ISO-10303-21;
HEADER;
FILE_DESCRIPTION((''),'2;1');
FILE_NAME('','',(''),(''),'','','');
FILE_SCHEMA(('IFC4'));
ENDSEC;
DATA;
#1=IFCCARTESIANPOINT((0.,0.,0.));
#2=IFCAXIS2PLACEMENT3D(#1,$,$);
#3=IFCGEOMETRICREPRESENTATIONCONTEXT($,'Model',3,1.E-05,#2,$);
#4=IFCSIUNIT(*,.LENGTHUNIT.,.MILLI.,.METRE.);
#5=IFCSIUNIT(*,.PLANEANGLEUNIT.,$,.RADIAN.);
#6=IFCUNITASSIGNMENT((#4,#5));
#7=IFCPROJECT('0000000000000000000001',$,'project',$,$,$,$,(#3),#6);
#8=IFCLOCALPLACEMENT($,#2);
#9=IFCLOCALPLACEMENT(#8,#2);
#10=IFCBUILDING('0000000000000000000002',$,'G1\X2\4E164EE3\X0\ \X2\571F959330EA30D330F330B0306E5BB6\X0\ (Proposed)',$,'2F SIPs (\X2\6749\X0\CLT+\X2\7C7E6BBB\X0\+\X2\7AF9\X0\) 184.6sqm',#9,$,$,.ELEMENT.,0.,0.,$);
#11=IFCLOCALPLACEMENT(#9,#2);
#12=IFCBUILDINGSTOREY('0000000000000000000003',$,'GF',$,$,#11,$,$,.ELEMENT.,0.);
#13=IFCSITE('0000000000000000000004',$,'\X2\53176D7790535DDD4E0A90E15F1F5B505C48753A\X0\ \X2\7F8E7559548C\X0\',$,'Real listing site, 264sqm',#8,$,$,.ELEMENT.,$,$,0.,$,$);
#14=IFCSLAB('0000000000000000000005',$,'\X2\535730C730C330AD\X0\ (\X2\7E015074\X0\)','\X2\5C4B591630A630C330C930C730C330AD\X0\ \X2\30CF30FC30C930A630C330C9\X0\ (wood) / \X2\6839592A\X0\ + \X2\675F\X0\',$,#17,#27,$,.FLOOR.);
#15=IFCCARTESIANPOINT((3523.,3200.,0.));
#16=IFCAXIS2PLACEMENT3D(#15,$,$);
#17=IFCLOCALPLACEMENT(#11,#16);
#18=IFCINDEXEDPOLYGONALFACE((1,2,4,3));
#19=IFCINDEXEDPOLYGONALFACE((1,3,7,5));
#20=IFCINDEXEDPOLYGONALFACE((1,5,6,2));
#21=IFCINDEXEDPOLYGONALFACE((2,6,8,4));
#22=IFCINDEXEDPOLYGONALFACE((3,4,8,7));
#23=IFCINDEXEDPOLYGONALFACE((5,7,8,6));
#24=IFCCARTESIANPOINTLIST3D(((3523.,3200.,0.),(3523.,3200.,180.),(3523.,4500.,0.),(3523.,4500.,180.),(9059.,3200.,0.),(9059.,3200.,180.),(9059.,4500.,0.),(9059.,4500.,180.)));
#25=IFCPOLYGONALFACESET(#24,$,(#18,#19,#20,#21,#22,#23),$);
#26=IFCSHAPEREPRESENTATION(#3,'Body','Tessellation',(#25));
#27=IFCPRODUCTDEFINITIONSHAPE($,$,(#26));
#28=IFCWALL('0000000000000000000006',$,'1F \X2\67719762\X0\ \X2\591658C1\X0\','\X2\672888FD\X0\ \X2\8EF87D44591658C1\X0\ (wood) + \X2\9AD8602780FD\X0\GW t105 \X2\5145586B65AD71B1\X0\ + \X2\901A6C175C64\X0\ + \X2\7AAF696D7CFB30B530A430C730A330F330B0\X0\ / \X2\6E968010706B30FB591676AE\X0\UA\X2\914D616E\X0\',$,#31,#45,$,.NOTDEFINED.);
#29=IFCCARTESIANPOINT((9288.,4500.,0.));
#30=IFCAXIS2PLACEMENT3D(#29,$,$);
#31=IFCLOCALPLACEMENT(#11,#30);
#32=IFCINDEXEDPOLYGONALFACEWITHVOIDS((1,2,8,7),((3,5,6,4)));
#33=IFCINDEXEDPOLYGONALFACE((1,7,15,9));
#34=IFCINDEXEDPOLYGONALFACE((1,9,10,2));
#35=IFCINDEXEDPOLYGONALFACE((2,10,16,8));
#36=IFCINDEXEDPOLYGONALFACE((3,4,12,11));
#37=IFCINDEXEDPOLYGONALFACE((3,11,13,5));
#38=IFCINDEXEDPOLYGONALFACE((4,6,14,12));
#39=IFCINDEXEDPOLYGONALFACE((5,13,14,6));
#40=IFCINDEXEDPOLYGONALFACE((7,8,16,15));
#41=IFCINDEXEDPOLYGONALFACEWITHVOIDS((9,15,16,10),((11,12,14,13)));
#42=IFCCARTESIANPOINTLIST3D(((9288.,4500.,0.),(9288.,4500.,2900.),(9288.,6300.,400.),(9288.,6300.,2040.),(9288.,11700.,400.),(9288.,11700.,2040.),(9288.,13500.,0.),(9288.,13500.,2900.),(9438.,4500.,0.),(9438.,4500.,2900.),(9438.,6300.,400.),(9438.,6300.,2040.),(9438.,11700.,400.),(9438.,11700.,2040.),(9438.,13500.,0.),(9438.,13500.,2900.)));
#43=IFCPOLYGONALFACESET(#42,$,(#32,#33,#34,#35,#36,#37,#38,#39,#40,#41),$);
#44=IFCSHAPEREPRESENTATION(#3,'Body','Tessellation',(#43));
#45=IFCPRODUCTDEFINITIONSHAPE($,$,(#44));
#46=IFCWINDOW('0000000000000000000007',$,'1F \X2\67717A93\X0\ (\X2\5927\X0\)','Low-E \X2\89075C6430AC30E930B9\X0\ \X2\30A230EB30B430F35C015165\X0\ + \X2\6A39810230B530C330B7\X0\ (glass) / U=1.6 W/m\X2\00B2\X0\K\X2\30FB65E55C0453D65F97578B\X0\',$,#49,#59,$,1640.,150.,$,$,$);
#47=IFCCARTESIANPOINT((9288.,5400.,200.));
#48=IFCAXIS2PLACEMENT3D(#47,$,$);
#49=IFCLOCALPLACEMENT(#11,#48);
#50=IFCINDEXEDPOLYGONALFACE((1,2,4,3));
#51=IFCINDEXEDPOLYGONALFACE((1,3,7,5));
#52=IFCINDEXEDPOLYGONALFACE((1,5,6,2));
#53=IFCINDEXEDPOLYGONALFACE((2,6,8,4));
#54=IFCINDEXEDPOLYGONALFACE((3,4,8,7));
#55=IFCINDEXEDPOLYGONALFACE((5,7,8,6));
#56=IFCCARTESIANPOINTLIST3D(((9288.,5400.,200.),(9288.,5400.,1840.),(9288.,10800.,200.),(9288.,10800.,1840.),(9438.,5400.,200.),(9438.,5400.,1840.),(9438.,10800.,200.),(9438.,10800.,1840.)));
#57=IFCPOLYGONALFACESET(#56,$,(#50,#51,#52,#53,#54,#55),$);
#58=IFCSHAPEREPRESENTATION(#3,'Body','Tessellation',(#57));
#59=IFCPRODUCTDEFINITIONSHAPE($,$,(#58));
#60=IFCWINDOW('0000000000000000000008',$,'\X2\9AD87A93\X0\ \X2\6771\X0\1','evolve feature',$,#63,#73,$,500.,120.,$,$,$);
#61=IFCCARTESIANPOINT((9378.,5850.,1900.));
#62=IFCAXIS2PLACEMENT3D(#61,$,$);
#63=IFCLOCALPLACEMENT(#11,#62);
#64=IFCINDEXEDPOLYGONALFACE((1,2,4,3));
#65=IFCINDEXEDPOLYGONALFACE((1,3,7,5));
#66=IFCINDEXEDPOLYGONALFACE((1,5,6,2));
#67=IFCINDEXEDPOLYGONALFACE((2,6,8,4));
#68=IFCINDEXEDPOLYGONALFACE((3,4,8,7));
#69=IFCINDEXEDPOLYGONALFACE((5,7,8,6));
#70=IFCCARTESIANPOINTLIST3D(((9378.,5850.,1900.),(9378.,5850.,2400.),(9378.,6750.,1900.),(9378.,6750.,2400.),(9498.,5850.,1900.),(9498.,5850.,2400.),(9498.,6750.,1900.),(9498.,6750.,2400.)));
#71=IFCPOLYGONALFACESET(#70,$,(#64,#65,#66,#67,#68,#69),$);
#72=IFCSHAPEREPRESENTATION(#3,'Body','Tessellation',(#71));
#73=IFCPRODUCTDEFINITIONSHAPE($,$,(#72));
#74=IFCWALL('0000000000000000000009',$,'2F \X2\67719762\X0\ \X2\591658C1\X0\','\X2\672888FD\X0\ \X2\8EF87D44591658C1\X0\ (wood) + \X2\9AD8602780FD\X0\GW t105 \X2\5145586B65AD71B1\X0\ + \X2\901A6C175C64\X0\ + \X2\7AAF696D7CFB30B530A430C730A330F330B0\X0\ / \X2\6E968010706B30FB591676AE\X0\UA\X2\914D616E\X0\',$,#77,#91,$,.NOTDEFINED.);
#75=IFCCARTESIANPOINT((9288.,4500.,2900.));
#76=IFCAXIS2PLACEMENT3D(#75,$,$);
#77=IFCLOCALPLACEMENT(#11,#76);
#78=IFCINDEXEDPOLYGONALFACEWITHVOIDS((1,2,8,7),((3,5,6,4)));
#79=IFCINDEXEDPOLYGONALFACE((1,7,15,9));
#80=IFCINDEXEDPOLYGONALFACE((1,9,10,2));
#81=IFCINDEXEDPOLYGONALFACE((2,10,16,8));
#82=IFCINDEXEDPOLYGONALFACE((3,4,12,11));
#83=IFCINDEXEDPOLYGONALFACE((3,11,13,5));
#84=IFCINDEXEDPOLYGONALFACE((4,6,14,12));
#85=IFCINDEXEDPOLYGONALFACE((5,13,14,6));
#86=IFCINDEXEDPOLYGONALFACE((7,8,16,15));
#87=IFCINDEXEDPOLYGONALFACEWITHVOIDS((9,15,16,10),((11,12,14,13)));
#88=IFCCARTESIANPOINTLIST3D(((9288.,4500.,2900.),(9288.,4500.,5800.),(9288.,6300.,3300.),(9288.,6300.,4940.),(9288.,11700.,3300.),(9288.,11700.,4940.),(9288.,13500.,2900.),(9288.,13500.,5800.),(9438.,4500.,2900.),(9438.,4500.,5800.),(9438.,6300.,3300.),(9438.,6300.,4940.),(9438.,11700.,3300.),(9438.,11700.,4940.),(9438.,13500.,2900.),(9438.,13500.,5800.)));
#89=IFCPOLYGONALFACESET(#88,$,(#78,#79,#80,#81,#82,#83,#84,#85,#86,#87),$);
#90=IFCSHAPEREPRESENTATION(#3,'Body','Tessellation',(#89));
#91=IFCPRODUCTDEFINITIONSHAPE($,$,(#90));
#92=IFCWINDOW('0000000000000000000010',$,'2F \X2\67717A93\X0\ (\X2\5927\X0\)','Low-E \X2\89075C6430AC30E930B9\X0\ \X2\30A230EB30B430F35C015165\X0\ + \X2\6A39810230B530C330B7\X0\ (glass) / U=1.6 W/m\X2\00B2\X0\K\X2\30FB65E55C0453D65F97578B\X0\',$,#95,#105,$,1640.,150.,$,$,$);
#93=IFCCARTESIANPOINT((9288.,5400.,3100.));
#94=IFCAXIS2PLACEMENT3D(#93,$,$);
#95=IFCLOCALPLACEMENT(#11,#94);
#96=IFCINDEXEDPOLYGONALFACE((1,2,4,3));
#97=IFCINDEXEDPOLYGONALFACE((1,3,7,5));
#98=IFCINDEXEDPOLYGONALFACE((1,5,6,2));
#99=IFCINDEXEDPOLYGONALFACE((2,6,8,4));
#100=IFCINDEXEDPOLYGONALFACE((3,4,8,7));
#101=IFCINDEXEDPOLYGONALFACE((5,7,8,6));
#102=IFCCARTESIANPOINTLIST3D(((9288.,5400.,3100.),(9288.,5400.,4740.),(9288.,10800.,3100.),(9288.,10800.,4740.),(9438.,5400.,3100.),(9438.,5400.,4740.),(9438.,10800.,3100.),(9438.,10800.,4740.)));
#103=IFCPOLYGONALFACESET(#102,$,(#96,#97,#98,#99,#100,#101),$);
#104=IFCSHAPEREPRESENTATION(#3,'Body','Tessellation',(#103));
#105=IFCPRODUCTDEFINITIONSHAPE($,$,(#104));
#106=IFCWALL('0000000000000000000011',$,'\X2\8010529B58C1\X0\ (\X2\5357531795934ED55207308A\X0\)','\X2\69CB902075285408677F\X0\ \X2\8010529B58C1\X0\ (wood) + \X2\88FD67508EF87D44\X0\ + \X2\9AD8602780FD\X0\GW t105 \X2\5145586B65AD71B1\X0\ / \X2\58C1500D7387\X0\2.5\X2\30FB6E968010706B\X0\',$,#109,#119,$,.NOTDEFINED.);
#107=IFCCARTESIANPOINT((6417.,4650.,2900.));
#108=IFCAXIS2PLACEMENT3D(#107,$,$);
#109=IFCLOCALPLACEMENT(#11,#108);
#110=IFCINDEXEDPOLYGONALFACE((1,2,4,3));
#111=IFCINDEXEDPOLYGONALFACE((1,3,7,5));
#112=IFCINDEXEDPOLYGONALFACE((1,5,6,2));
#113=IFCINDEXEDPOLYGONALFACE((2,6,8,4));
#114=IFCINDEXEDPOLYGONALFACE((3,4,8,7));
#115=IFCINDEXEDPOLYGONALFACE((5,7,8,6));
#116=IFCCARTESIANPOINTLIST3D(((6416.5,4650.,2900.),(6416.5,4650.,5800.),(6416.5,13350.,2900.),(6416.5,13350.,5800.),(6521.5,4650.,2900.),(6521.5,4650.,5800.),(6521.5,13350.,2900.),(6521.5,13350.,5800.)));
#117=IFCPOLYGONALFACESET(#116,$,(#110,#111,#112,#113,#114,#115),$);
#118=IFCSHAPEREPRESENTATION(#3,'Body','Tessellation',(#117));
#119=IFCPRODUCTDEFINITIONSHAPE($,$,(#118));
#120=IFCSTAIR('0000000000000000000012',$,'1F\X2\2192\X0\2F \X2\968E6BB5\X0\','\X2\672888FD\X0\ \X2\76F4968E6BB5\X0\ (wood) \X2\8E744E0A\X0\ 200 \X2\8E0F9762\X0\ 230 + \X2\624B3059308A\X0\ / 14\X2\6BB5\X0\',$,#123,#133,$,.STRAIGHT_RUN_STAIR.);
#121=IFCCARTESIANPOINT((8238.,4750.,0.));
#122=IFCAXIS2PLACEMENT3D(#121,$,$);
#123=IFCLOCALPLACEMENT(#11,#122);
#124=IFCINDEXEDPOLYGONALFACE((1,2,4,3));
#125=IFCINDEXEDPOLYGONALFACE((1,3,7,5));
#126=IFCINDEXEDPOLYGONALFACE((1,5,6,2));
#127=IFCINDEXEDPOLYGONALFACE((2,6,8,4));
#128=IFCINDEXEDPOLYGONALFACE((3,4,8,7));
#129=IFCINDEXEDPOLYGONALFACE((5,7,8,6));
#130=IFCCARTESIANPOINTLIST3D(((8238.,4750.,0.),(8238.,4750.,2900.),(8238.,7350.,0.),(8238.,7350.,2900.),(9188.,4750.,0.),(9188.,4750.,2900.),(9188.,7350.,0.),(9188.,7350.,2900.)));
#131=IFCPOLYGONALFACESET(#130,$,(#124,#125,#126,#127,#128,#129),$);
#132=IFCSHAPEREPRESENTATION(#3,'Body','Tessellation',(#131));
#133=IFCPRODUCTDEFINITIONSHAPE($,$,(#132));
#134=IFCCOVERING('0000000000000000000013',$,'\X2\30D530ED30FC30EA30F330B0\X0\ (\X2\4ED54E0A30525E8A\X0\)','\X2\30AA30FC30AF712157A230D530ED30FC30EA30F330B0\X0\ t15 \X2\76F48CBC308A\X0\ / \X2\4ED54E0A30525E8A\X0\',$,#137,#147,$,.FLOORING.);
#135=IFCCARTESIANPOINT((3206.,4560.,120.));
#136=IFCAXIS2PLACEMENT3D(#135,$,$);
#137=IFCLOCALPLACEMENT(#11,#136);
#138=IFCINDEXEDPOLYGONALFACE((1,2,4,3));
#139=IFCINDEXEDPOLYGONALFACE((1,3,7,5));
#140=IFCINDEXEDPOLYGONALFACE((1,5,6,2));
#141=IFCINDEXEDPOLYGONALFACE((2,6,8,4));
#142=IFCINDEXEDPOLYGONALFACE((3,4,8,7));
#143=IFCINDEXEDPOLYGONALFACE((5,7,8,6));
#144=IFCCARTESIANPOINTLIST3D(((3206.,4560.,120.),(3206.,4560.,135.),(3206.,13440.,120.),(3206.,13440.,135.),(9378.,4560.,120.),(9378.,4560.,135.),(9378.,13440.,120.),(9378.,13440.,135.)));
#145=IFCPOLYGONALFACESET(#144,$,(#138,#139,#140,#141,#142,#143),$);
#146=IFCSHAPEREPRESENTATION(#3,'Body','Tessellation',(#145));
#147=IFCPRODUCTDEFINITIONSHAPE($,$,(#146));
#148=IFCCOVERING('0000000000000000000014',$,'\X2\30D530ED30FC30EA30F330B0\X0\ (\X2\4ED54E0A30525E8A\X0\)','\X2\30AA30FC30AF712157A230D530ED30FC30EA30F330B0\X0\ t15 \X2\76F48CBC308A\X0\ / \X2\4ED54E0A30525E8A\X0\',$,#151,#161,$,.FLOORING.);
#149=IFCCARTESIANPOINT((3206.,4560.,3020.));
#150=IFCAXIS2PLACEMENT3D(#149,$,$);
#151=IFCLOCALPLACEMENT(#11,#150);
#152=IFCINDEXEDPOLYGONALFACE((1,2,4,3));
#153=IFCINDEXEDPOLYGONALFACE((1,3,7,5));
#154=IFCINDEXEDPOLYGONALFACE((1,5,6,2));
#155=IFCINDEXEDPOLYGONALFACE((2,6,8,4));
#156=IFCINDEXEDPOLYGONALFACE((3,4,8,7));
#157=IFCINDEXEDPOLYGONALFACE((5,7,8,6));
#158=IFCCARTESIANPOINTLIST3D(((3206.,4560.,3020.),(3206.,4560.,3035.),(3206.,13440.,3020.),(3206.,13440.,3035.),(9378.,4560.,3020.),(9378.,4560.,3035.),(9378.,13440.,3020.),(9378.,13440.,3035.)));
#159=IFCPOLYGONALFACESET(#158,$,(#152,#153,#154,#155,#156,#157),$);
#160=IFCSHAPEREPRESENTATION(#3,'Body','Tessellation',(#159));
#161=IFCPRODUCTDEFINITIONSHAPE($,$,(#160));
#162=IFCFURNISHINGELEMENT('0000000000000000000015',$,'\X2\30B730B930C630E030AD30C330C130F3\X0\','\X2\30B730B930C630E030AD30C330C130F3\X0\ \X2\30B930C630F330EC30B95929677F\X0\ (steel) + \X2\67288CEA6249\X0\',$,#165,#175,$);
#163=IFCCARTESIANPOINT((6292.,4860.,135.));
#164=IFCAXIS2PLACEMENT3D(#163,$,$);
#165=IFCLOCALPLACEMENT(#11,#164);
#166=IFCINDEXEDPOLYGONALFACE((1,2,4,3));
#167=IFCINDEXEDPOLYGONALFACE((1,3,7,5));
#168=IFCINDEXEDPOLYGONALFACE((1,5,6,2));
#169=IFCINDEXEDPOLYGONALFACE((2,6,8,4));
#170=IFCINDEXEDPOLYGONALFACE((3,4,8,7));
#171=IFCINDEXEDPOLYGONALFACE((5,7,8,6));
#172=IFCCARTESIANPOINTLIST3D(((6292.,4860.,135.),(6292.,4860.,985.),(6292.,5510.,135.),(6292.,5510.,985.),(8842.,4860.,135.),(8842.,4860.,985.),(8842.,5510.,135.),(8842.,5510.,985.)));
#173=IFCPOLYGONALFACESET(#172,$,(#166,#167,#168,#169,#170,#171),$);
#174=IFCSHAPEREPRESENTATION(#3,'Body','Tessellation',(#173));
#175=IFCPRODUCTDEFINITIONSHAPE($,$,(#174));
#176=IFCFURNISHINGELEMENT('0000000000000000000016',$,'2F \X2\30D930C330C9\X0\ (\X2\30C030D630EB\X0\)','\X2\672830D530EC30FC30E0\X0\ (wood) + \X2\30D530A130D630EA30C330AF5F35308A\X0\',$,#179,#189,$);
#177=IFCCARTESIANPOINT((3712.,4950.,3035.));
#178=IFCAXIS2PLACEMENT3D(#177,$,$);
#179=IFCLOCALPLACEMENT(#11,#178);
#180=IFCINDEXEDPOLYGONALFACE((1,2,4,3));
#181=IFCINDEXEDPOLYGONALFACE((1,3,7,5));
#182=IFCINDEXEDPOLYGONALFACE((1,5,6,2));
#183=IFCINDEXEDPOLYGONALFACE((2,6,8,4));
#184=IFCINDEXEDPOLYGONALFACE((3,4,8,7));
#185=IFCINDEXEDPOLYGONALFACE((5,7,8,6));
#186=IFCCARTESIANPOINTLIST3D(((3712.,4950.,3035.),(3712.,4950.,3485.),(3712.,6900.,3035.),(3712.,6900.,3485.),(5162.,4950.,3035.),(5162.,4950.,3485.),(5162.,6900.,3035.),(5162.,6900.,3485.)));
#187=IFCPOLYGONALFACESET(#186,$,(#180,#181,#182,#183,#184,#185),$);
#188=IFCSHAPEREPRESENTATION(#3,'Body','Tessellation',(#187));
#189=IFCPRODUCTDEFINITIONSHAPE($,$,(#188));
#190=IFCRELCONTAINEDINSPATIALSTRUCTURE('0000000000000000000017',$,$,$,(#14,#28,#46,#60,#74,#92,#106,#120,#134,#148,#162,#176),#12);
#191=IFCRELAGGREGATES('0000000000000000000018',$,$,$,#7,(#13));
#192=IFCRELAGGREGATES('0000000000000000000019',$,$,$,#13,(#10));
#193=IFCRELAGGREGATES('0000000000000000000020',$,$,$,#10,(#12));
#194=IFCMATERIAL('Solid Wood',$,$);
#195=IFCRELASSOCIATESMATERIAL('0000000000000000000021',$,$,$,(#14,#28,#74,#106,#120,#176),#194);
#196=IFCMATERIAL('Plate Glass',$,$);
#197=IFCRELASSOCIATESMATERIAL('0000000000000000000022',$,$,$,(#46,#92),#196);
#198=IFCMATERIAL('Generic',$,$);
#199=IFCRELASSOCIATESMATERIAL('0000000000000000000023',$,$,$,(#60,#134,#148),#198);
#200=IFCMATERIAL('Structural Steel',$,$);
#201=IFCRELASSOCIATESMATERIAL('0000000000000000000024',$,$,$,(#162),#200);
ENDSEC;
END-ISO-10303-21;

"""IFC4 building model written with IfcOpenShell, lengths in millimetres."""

from ifc_helpers import new_model, si_unit, frame, frame_2d, origin, place, context, project, spatial, rectangle, extrude, material, element, fill, save


model = new_model("IFC4")

# Units and contexts
model_context = context("Model", 3, precision=1e-05, world=origin())
ifc_project = project(units=[si_unit("LENGTHUNIT", "METRE", prefix="MILLI"), si_unit("PLANEANGLEUNIT", "RADIAN")], contexts=[model_context])

# Site, building, storey
site_placement = place(None, origin())
site = spatial("IfcSite", under=ifc_project, at=site_placement, Name="北海道川上郡弟子屈町 美留和", ObjectType="Real listing site, 264sqm", CompositionType="ELEMENT", RefElevation=0.0)
building_placement = place(site_placement, origin())
building = spatial("IfcBuilding", under=site, at=building_placement, Name="G1世代 土間リビングの家 (Proposed)", ObjectType="2F SIPs (杉CLT+籾殻+竹) 184.6sqm", CompositionType="ELEMENT", ElevationOfRefHeight=0.0, ElevationOfTerrain=0.0)
storey_placement = place(building_placement, origin())
storey = spatial("IfcBuildingStorey", under=building, at=storey_placement, Name="GF", CompositionType="ELEMENT", Elevation=0.0)

# Slab
ifc_material_1 = material(Name="Solid Wood")
slab_placement = place(storey_placement, frame((3523.0, 3200.0, 0.0)))
element("IfcSlab", 1, at=slab_placement, inside=storey, material=ifc_material_1, Name="南デッキ (縁側)", Description="屋外ウッドデッキ ハードウッド (wood) / 根太 + 束", PredefinedType="FLOOR", context=model_context, shape_type="SweptSolid", body=[
    extrude(rectangle(XDim=5536.0, YDim=1300.0, at=frame_2d((2768.0, 650.0))), frame((3523.0, 3200.0, 0.0)), (0.0, 0.0, 1.0), 180.0),
])

# Wall, openings, windows
wall_1_placement = place(storey_placement, frame((9288.0, 4500.0, 0.0)))
wall_1 = element("IfcWall", 2, at=wall_1_placement, inside=storey, material=ifc_material_1, Name="1F 東面 外壁", Description="木製 軸組外壁 (wood) + 高性能GW t105 充填断熱 + 通気層 + 窯業系サイディング / 準耐火・外皮UA配慮", PredefinedType="NOTDEFINED", context=model_context, shape_type="SweptSolid", body=[
    extrude(rectangle(XDim=150.0, YDim=9000.0, at=frame_2d((75.0, 4500.0))), frame((9288.0, 4500.0, 0.0)), (0.0, 0.0, 1.0), 2900.0),
])
opening_1_placement = place(storey_placement, frame((9288.0, 5400.0, 200.0)))
opening_1 = element("IfcOpeningElement", 3, at=opening_1_placement, cuts=wall_1, PredefinedType="NOTDEFINED", context=model_context, shape_type="SweptSolid", body=[
    extrude(rectangle(XDim=150.0, YDim=5400.0, at=frame_2d((75.0, 2700.0))), frame((9288.0, 5400.0, 200.0)), (0.0, 0.0, 1.0), 1640.0),
])
opening_2_placement = place(storey_placement, frame((9378.0, 5850.0, 1900.0)))
opening_2 = element("IfcOpeningElement", 4, at=opening_2_placement, cuts=wall_1, PredefinedType="NOTDEFINED", context=model_context, shape_type="SweptSolid", body=[
    extrude(rectangle(XDim=120.0, YDim=900.0, at=frame_2d((60.0, 450.0))), frame((9378.0, 5850.0, 1900.0)), (0.0, 0.0, 1.0), 500.0),
])
ifc_material_2 = material(Name="Plate Glass")
window_1_placement = place(storey_placement, frame((9288.0, 5400.0, 200.0)))
window_1 = element("IfcWindow", 5, at=window_1_placement, inside=storey, material=ifc_material_2, Name="1F 東窓 (大)", Description="Low-E 複層ガラス アルゴン封入 + 樹脂サッシ (glass) / U=1.6 W/m²K・日射取得型", OverallHeight=1640.0, OverallWidth=150.0, context=model_context, shape_type="SweptSolid", body=[
    extrude(rectangle(XDim=150.0, YDim=5400.0, at=frame_2d((75.0, 2700.0))), frame((9288.0, 5400.0, 200.0)), (0.0, 0.0, 1.0), 1640.0),
])
fill(opening_1, window_1)
ifc_material_3 = material(Name="Generic")
window_2_placement = place(storey_placement, frame((9378.0, 5850.0, 1900.0)))
window_2 = element("IfcWindow", 6, at=window_2_placement, inside=storey, material=ifc_material_3, Name="高窓 東1", Description="evolve feature", OverallHeight=500.0, OverallWidth=120.0, context=model_context, shape_type="SweptSolid", body=[
    extrude(rectangle(XDim=120.0, YDim=900.0, at=frame_2d((60.0, 450.0))), frame((9378.0, 5850.0, 1900.0)), (0.0, 0.0, 1.0), 500.0),
])
fill(opening_2, window_2)

# Wall, opening, window
wall_2_placement = place(storey_placement, frame((9288.0, 4500.0, 2900.0)))
wall_2 = element("IfcWall", 7, at=wall_2_placement, inside=storey, material=ifc_material_1, Name="2F 東面 外壁", Description="木製 軸組外壁 (wood) + 高性能GW t105 充填断熱 + 通気層 + 窯業系サイディング / 準耐火・外皮UA配慮", PredefinedType="NOTDEFINED", context=model_context, shape_type="SweptSolid", body=[
    extrude(rectangle(XDim=150.0, YDim=9000.0, at=frame_2d((75.0, 4500.0))), frame((9288.0, 4500.0, 2900.0)), (0.0, 0.0, 1.0), 2900.0),
])
opening_3_placement = place(storey_placement, frame((9288.0, 5400.0, 3100.0)))
opening_3 = element("IfcOpeningElement", 8, at=opening_3_placement, cuts=wall_2, PredefinedType="NOTDEFINED", context=model_context, shape_type="SweptSolid", body=[
    extrude(rectangle(XDim=150.0, YDim=5400.0, at=frame_2d((75.0, 2700.0))), frame((9288.0, 5400.0, 3100.0)), (0.0, 0.0, 1.0), 1640.0),
])
window_3_placement = place(storey_placement, frame((9288.0, 5400.0, 3100.0)))
window_3 = element("IfcWindow", 9, at=window_3_placement, inside=storey, material=ifc_material_2, Name="2F 東窓 (大)", Description="Low-E 複層ガラス アルゴン封入 + 樹脂サッシ (glass) / U=1.6 W/m²K・日射取得型", OverallHeight=1640.0, OverallWidth=150.0, context=model_context, shape_type="SweptSolid", body=[
    extrude(rectangle(XDim=150.0, YDim=5400.0, at=frame_2d((75.0, 2700.0))), frame((9288.0, 5400.0, 3100.0)), (0.0, 0.0, 1.0), 1640.0),
])
fill(opening_3, window_3)

# Wall
wall_3_placement = place(storey_placement, frame((6417.0, 4650.0, 2900.0)))
element("IfcWall", 10, at=wall_3_placement, inside=storey, material=ifc_material_1, Name="耐力壁 (南北間仕切り)", Description="構造用合板 耐力壁 (wood) + 製材軸組 + 高性能GW t105 充填断熱 / 壁倍率2.5・準耐火", PredefinedType="NOTDEFINED", context=model_context, shape_type="SweptSolid", body=[
    extrude(rectangle(XDim=105.0, YDim=8700.0, at=frame_2d((52.0, 4350.0))), frame((6417.0, 4650.0, 2900.0)), (0.0, 0.0, 1.0), 2900.0),
])

# Stair
stair_placement = place(storey_placement, frame((8238.0, 4750.0, 0.0)))
element("IfcStair", 11, at=stair_placement, inside=storey, material=ifc_material_1, Name="1F→2F 階段", Description="木製 直階段 (wood) 蹴上 200 踏面 230 + 手すり / 14段", PredefinedType="STRAIGHT_RUN_STAIR", context=model_context, shape_type="SweptSolid", body=[
    extrude(rectangle(XDim=950.0, YDim=2600.0, at=frame_2d((475.0, 1300.0))), frame((8238.0, 4750.0, 0.0)), (0.0, 0.0, 1.0), 2900.0),
])

# Coverings
covering_1_placement = place(storey_placement, frame((3206.0, 4560.0, 120.0)))
element("IfcCovering", 12, at=covering_1_placement, inside=storey, material=ifc_material_3, Name="フローリング (仕上げ床)", Description="オーク無垢フローリング t15 直貼り / 仕上げ床", PredefinedType="FLOORING", context=model_context, shape_type="SweptSolid", body=[
    extrude(rectangle(XDim=6172.0, YDim=8880.0, at=frame_2d((3086.0, 4440.0))), frame((3206.0, 4560.0, 120.0)), (0.0, 0.0, 1.0), 15.0),
])
covering_2_placement = place(storey_placement, frame((3206.0, 4560.0, 3020.0)))
element("IfcCovering", 13, at=covering_2_placement, inside=storey, material=ifc_material_3, Name="フローリング (仕上げ床)", Description="オーク無垢フローリング t15 直貼り / 仕上げ床", PredefinedType="FLOORING", context=model_context, shape_type="SweptSolid", body=[
    extrude(rectangle(XDim=6172.0, YDim=8880.0, at=frame_2d((3086.0, 4440.0))), frame((3206.0, 4560.0, 3020.0)), (0.0, 0.0, 1.0), 15.0),
])

# Furnishing elements
ifc_material_4 = material(Name="Structural Steel")
furnishing_1_placement = place(storey_placement, frame((6292.0, 4860.0, 135.0)))
element("IfcFurnishingElement", 14, at=furnishing_1_placement, inside=storey, material=ifc_material_4, Name="システムキッチン", Description="システムキッチン ステンレス天板 (steel) + 木質扉", context=model_context, shape_type="SweptSolid", body=[
    extrude(rectangle(XDim=2550.0, YDim=650.0, at=frame_2d((1275.0, 325.0))), frame((6292.0, 4860.0, 135.0)), (0.0, 0.0, 1.0), 850.0),
])
furnishing_2_placement = place(storey_placement, frame((3712.0, 4950.0, 3035.0)))
element("IfcFurnishingElement", 15, at=furnishing_2_placement, inside=storey, material=ifc_material_1, Name="2F ベッド (ダブル)", Description="木フレーム (wood) + ファブリック張り", context=model_context, shape_type="SweptSolid", body=[
    extrude(rectangle(XDim=1450.0, YDim=1950.0, at=frame_2d((725.0, 975.0))), frame((3712.0, 4950.0, 3035.0)), (0.0, 0.0, 1.0), 450.0),
])

save(model, "model.ifc")
